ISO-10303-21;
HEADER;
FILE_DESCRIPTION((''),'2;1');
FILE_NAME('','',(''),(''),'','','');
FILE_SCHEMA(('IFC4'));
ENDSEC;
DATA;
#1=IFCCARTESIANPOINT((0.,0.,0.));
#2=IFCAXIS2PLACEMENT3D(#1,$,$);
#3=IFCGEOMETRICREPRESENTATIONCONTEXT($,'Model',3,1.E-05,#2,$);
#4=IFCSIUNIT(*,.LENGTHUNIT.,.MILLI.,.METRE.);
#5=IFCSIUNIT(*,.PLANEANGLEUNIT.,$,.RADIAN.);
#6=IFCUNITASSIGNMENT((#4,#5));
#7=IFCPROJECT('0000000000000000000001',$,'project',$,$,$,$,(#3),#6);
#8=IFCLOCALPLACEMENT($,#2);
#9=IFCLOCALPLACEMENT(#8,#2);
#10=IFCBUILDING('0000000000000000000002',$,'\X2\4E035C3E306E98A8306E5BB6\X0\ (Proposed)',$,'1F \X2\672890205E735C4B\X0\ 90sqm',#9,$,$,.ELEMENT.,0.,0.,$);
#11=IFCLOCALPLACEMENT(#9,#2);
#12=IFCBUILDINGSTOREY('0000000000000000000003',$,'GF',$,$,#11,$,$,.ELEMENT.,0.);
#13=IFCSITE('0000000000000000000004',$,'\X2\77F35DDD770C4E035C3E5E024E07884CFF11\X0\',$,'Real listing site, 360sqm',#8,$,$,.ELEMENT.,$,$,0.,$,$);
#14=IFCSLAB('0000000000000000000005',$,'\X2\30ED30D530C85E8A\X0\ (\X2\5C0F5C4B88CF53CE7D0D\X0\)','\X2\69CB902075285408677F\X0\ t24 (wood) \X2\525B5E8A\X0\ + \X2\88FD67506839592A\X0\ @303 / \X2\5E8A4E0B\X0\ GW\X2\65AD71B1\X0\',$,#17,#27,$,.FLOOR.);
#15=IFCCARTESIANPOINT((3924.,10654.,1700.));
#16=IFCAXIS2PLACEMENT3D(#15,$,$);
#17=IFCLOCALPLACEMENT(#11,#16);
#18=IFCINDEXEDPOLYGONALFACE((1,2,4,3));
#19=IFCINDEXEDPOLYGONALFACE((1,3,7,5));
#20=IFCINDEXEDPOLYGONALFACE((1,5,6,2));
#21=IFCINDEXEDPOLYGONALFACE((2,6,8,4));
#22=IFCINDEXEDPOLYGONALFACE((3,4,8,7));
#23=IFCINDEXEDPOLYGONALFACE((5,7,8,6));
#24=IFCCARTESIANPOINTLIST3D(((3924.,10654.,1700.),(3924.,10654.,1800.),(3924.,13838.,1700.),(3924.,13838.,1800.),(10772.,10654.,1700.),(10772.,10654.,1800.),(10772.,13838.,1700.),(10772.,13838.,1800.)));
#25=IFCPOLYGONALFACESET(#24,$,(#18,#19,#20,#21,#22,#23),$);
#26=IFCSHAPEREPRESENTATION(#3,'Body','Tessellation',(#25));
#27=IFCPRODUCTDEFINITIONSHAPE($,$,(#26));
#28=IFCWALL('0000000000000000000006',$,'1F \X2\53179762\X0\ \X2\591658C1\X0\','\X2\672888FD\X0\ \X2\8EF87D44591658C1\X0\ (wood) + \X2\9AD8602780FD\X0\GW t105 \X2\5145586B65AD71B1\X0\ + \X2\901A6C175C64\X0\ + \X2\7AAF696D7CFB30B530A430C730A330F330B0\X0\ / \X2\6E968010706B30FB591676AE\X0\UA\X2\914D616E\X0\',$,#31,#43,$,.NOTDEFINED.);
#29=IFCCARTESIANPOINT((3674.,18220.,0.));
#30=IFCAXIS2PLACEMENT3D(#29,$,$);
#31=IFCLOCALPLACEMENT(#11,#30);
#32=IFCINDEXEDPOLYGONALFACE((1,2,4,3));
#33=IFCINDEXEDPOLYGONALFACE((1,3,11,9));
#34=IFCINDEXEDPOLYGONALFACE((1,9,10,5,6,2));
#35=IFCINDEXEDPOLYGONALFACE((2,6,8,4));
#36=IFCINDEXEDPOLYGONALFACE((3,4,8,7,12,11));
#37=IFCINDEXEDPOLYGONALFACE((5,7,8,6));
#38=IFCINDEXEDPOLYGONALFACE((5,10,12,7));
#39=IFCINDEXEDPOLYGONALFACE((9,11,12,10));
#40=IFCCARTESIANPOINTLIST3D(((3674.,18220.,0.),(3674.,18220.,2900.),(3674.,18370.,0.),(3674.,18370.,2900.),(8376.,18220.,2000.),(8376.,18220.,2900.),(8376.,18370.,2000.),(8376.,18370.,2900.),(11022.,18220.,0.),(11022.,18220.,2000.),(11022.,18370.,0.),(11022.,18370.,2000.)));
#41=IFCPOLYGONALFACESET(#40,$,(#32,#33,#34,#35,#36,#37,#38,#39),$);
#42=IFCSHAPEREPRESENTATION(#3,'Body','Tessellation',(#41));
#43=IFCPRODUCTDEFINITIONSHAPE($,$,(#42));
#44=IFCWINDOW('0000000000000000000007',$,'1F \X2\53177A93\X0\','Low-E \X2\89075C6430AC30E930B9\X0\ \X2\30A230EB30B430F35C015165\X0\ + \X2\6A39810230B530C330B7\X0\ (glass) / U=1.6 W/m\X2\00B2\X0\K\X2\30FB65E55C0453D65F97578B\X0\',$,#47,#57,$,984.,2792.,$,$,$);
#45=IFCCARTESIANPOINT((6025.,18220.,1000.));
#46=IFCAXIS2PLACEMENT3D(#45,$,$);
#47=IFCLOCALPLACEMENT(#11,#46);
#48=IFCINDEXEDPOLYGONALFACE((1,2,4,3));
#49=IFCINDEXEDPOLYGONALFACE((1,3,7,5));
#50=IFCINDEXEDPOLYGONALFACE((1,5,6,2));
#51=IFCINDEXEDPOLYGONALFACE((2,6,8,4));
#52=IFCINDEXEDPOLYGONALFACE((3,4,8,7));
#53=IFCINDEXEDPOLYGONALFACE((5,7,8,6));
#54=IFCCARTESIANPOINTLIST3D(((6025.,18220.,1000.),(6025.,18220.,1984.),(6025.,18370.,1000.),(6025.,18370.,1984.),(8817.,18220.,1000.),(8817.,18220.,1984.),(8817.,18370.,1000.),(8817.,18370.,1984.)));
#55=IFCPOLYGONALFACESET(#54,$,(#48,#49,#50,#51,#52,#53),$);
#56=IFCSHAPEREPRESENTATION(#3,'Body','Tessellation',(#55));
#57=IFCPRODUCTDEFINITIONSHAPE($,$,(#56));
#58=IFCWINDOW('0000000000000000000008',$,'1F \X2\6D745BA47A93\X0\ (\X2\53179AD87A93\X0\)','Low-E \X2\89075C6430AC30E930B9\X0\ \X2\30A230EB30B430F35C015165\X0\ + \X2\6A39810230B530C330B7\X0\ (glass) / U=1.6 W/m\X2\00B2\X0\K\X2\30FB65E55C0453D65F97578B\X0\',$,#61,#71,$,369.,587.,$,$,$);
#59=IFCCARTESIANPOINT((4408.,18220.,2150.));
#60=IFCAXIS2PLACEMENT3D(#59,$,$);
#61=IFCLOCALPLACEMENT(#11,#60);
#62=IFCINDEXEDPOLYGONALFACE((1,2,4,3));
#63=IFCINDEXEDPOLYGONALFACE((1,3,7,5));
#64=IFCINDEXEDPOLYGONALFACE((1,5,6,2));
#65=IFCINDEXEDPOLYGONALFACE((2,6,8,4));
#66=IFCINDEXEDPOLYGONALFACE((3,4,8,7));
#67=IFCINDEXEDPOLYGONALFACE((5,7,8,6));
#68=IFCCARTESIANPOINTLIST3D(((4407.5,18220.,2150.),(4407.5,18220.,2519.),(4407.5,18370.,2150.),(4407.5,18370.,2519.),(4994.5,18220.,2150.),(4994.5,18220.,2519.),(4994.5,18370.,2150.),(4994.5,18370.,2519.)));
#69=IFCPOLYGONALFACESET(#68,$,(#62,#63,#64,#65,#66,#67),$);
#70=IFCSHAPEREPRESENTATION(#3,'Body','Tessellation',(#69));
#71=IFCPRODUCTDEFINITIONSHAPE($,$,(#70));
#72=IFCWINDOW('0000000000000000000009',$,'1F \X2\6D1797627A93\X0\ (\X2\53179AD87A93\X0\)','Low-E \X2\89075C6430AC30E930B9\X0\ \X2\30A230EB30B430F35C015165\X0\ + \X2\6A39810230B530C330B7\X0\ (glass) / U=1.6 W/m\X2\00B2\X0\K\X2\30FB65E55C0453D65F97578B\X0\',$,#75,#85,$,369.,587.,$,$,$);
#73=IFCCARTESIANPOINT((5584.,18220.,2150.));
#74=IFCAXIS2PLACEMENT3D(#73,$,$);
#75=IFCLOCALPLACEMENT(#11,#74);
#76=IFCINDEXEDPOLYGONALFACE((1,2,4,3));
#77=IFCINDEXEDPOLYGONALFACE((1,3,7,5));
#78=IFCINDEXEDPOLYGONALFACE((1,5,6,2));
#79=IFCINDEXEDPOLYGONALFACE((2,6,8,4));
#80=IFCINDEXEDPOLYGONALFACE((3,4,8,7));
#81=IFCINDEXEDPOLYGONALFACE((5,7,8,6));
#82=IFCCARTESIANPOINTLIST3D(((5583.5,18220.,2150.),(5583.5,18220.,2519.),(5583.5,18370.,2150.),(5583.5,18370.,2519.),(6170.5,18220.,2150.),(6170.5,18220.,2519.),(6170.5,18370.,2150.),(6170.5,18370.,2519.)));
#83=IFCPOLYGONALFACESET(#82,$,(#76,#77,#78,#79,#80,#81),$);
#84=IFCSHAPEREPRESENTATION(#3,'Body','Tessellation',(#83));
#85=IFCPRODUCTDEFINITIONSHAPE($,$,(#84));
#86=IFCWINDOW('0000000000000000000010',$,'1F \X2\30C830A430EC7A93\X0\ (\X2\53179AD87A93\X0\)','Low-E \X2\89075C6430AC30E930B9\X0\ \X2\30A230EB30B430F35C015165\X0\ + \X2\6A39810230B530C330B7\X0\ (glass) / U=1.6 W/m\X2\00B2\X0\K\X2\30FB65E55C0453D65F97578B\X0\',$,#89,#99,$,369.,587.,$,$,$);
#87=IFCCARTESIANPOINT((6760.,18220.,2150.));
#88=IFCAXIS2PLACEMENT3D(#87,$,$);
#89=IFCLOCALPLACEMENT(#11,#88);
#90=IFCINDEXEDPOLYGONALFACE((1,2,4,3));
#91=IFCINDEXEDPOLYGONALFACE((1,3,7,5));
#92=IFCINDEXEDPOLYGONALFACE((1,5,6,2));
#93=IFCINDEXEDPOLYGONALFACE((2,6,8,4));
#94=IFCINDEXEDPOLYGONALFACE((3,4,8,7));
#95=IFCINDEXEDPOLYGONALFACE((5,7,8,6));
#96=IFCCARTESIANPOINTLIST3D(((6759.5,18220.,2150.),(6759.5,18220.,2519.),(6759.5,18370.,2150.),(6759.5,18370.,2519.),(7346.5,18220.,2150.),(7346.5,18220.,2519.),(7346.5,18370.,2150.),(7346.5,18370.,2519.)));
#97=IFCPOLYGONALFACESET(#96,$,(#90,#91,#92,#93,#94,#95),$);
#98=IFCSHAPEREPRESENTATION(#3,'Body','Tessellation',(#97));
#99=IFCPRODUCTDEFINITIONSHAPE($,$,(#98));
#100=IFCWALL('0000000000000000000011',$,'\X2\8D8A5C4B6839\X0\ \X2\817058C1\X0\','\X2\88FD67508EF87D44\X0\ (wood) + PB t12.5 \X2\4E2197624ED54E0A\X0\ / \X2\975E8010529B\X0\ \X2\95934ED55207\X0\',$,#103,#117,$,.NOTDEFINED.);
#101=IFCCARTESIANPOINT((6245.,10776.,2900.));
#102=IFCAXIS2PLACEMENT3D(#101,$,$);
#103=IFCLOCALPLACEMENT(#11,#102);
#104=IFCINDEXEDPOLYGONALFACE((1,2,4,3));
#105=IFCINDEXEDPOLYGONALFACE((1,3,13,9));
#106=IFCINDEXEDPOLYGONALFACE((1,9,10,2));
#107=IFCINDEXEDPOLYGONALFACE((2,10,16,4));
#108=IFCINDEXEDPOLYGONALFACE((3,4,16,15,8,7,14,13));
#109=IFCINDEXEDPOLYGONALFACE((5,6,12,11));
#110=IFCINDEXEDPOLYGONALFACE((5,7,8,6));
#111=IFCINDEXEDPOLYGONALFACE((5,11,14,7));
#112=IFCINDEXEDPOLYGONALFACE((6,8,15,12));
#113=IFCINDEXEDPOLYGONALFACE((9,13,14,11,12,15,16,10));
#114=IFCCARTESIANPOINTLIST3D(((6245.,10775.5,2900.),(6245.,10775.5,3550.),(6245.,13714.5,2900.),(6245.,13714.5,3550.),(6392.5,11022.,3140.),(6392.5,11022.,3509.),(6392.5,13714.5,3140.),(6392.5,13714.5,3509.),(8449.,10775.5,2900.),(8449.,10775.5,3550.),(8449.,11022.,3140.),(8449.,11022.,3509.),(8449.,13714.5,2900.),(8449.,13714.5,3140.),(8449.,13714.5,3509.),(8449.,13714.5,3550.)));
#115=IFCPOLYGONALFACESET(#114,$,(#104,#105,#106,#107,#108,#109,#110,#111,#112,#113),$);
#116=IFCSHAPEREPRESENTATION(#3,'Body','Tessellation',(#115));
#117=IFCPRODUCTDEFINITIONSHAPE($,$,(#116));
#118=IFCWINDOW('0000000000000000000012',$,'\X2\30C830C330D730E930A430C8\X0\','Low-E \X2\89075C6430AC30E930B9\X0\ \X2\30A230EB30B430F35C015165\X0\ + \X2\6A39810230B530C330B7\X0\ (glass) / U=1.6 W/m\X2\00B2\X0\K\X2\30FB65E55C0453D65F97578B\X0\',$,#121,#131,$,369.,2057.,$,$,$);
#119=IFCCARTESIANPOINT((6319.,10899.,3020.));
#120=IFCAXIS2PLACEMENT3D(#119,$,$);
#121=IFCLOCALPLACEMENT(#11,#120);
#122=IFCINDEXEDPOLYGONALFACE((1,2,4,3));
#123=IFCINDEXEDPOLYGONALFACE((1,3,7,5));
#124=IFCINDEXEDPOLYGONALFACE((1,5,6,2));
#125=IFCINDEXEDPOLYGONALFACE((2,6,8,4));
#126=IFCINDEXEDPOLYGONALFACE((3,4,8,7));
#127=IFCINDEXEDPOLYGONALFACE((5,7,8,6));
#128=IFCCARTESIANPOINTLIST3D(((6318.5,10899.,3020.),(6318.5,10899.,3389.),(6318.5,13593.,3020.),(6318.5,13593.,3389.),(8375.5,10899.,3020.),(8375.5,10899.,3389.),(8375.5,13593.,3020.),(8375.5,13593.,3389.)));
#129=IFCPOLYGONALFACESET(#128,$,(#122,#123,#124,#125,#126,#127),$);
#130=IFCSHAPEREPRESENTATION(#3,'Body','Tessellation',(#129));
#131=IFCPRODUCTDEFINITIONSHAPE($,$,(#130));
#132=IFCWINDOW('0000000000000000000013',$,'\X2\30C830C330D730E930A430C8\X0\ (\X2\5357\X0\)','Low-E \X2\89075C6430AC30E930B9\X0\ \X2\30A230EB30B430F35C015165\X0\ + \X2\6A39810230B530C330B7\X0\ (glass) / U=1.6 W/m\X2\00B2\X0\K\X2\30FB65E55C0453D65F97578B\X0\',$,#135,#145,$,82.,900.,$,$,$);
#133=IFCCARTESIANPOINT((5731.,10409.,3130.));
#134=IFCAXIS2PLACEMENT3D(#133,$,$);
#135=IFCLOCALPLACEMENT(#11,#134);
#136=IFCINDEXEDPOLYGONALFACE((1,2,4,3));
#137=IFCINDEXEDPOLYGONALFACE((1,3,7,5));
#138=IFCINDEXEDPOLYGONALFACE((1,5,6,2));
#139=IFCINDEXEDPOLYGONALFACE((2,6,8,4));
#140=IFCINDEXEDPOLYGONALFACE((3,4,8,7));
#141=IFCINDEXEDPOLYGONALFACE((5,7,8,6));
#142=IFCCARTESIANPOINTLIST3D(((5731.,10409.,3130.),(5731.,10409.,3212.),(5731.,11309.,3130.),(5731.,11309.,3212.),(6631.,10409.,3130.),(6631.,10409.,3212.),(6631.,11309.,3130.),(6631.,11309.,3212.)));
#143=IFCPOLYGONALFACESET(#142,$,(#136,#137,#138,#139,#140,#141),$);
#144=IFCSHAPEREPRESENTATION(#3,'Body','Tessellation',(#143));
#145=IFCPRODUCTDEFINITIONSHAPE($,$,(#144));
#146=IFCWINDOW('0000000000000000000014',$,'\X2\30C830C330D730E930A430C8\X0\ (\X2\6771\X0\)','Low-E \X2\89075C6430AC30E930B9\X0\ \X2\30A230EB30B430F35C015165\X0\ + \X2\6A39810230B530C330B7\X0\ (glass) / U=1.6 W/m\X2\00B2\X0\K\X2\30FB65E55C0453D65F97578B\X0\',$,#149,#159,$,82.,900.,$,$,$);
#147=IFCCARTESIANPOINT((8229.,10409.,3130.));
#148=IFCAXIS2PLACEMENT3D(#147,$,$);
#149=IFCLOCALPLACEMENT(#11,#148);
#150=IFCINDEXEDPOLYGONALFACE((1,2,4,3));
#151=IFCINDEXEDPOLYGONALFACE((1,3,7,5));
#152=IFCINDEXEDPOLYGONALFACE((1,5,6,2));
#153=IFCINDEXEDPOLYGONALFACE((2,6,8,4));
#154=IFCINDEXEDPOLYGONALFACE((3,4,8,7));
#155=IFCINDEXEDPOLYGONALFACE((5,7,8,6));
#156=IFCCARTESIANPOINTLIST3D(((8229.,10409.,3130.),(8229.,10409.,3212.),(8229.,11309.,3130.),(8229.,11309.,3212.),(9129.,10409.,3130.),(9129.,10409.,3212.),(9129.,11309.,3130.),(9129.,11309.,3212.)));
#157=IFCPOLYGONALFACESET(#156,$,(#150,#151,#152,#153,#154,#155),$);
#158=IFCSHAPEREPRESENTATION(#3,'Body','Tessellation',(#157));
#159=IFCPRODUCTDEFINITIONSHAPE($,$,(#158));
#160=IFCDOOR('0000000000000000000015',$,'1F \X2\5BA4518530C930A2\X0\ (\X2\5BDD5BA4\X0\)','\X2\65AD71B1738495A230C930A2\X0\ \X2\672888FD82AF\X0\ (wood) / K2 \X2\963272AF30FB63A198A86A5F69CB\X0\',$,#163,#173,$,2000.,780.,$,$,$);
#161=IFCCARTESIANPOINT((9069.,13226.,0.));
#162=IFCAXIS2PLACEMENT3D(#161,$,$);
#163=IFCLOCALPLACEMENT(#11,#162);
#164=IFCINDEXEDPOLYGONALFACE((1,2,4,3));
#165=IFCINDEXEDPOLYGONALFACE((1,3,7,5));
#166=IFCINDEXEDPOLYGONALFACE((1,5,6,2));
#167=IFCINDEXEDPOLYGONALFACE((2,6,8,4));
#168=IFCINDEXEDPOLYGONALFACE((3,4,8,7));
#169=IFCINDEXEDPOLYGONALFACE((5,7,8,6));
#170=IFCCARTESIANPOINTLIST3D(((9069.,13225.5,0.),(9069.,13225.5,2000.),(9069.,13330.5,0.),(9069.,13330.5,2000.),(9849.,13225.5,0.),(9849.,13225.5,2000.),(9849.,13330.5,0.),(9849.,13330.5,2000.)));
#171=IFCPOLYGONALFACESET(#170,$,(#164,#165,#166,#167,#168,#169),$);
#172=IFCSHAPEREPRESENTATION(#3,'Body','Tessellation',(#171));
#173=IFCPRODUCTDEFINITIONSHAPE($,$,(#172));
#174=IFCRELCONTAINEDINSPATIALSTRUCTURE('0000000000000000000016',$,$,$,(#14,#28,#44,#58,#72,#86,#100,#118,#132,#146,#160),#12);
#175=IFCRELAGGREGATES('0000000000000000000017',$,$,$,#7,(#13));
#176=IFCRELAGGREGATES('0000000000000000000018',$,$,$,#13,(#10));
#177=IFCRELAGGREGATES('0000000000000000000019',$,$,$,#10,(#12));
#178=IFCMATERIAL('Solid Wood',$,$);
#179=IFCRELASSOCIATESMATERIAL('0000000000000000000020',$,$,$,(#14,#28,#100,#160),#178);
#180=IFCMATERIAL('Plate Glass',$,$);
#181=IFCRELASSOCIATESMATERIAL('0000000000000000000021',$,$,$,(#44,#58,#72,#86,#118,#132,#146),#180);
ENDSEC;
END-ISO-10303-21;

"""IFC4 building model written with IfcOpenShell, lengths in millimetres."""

from ifc_helpers import new_model, si_unit, frame, frame_2d, origin, place, context, project, spatial, rectangle, extrude, material, element, fill, save


model = new_model("IFC4")

# Units and contexts
model_context = context("Model", 3, precision=1e-05, world=origin())
ifc_project = project(units=[si_unit("LENGTHUNIT", "METRE", prefix="MILLI"), si_unit("PLANEANGLEUNIT", "RADIAN")], contexts=[model_context])

# Site, building, storey
site_placement = place(None, origin())
site = spatial("IfcSite", under=ifc_project, at=site_placement, Name="石川県七尾市万行１", ObjectType="Real listing site, 360sqm", CompositionType="ELEMENT", RefElevation=0.0)
building_placement = place(site_placement, origin())
building = spatial("IfcBuilding", under=site, at=building_placement, Name="七尾の風の家 (Proposed)", ObjectType="1F 木造平屋 90sqm", CompositionType="ELEMENT", ElevationOfRefHeight=0.0, ElevationOfTerrain=0.0)
storey_placement = place(building_placement, origin())
storey = spatial("IfcBuildingStorey", under=building, at=storey_placement, Name="GF", CompositionType="ELEMENT", Elevation=0.0)

# Slab
ifc_material_1 = material(Name="Solid Wood")
slab_placement = place(storey_placement, frame((3924.0, 10654.0, 1700.0)))
element("IfcSlab", 1, at=slab_placement, inside=storey, material=ifc_material_1, Name="ロフト床 (小屋裏収納)", Description="構造用合板 t24 (wood) 剛床 + 製材根太 @303 / 床下 GW断熱", PredefinedType="FLOOR", context=model_context, shape_type="SweptSolid", body=[
    extrude(rectangle(XDim=6848.0, YDim=3184.0, at=frame_2d((3424.0, 1592.0))), frame((3924.0, 10654.0, 1700.0)), (0.0, 0.0, 1.0), 100.0),
])

# Wall, openings, windows
wall_1_placement = place(storey_placement, frame((3674.0, 18220.0, 0.0)))
wall_1 = element("IfcWall", 2, at=wall_1_placement, inside=storey, material=ifc_material_1, Name="1F 北面 外壁", Description="木製 軸組外壁 (wood) + 高性能GW t105 充填断熱 + 通気層 + 窯業系サイディング / 準耐火・外皮UA配慮", PredefinedType="NOTDEFINED", context=model_context, shape_type="SweptSolid", body=[
    extrude(rectangle(XDim=7348.0, YDim=150.0, at=frame_2d((3674.0, 75.0))), frame((3674.0, 18220.0, 0.0)), (0.0, 0.0, 1.0), 2900.0),
])
opening_1_placement = place(storey_placement, frame((6025.0, 18220.0, 1000.0)))
opening_1 = element("IfcOpeningElement", 3, at=opening_1_placement, cuts=wall_1, PredefinedType="NOTDEFINED", context=model_context, shape_type="SweptSolid", body=[
    extrude(rectangle(XDim=2792.0, YDim=150.0, at=frame_2d((1396.0, 75.0))), frame((6025.0, 18220.0, 1000.0)), (0.0, 0.0, 1.0), 984.0),
])
opening_2_placement = place(storey_placement, frame((4408.0, 18220.0, 2150.0)))
opening_2 = element("IfcOpeningElement", 4, at=opening_2_placement, cuts=wall_1, PredefinedType="NOTDEFINED", context=model_context, shape_type="SweptSolid", body=[
    extrude(rectangle(XDim=587.0, YDim=150.0, at=frame_2d((293.0, 75.0))), frame((4408.0, 18220.0, 2150.0)), (0.0, 0.0, 1.0), 369.0),
])
opening_3_placement = place(storey_placement, frame((5584.0, 18220.0, 2150.0)))
opening_3 = element("IfcOpeningElement", 5, at=opening_3_placement, cuts=wall_1, PredefinedType="NOTDEFINED", context=model_context, shape_type="SweptSolid", body=[
    extrude(rectangle(XDim=587.0, YDim=150.0, at=frame_2d((293.0, 75.0))), frame((5584.0, 18220.0, 2150.0)), (0.0, 0.0, 1.0), 369.0),
])
opening_4_placement = place(storey_placement, frame((6760.0, 18220.0, 2150.0)))
opening_4 = element("IfcOpeningElement", 6, at=opening_4_placement, cuts=wall_1, PredefinedType="NOTDEFINED", context=model_context, shape_type="SweptSolid", body=[
    extrude(rectangle(XDim=587.0, YDim=150.0, at=frame_2d((293.0, 75.0))), frame((6760.0, 18220.0, 2150.0)), (0.0, 0.0, 1.0), 369.0),
])
ifc_material_2 = material(Name="Plate Glass")
window_1_placement = place(storey_placement, frame((6025.0, 18220.0, 1000.0)))
window_1 = element("IfcWindow", 7, at=window_1_placement, inside=storey, material=ifc_material_2, Name="1F 北窓", Description="Low-E 複層ガラス アルゴン封入 + 樹脂サッシ (glass) / U=1.6 W/m²K・日射取得型", OverallHeight=984.0, OverallWidth=2792.0, context=model_context, shape_type="SweptSolid", body=[
    extrude(rectangle(XDim=2792.0, YDim=150.0, at=frame_2d((1396.0, 75.0))), frame((6025.0, 18220.0, 1000.0)), (0.0, 0.0, 1.0), 984.0),
])
fill(opening_1, window_1)
window_2_placement = place(storey_placement, frame((4408.0, 18220.0, 2150.0)))
window_2 = element("IfcWindow", 8, at=window_2_placement, inside=storey, material=ifc_material_2, Name="1F 浴室窓 (北高窓)", Description="Low-E 複層ガラス アルゴン封入 + 樹脂サッシ (glass) / U=1.6 W/m²K・日射取得型", OverallHeight=369.0, OverallWidth=587.0, context=model_context, shape_type="SweptSolid", body=[
    extrude(rectangle(XDim=587.0, YDim=150.0, at=frame_2d((293.0, 75.0))), frame((4408.0, 18220.0, 2150.0)), (0.0, 0.0, 1.0), 369.0),
])
fill(opening_2, window_2)
window_3_placement = place(storey_placement, frame((5584.0, 18220.0, 2150.0)))
window_3 = element("IfcWindow", 9, at=window_3_placement, inside=storey, material=ifc_material_2, Name="1F 洗面窓 (北高窓)", Description="Low-E 複層ガラス アルゴン封入 + 樹脂サッシ (glass) / U=1.6 W/m²K・日射取得型", OverallHeight=369.0, OverallWidth=587.0, context=model_context, shape_type="SweptSolid", body=[
    extrude(rectangle(XDim=587.0, YDim=150.0, at=frame_2d((293.0, 75.0))), frame((5584.0, 18220.0, 2150.0)), (0.0, 0.0, 1.0), 369.0),
])
fill(opening_3, window_3)
window_4_placement = place(storey_placement, frame((6760.0, 18220.0, 2150.0)))
window_4 = element("IfcWindow", 10, at=window_4_placement, inside=storey, material=ifc_material_2, Name="1F トイレ窓 (北高窓)", Description="Low-E 複層ガラス アルゴン封入 + 樹脂サッシ (glass) / U=1.6 W/m²K・日射取得型", OverallHeight=369.0, OverallWidth=587.0, context=model_context, shape_type="SweptSolid", body=[
    extrude(rectangle(XDim=587.0, YDim=150.0, at=frame_2d((293.0, 75.0))), frame((6760.0, 18220.0, 2150.0)), (0.0, 0.0, 1.0), 369.0),
])
fill(opening_4, window_4)

# Wall, openings, windows
wall_2_placement = place(storey_placement, frame((6245.0, 10776.0, 2900.0)))
wall_2 = element("IfcWall", 11, at=wall_2_placement, inside=storey, material=ifc_material_1, Name="越屋根 腰壁", Description="製材軸組 (wood) + PB t12.5 両面仕上 / 非耐力 間仕切", PredefinedType="NOTDEFINED", context=model_context, shape_type="SweptSolid", body=[
    extrude(rectangle(XDim=2204.0, YDim=2939.0, at=frame_2d((1102.0, 1469.0))), frame((6245.0, 10776.0, 2900.0)), (0.0, 0.0, 1.0), 650.0),
])
opening_5_placement = place(storey_placement, frame((6319.0, 10899.0, 3020.0)))
opening_5 = element("IfcOpeningElement", 12, at=opening_5_placement, cuts=wall_2, PredefinedType="NOTDEFINED", context=model_context, shape_type="SweptSolid", body=[
    extrude(rectangle(XDim=2057.0, YDim=2694.0, at=frame_2d((1028.0, 1347.0))), frame((6319.0, 10899.0, 3020.0)), (0.0, 0.0, 1.0), 369.0),
])
opening_6_placement = place(storey_placement, frame((5731.0, 10409.0, 3130.0)))
opening_6 = element("IfcOpeningElement", 13, at=opening_6_placement, cuts=wall_2, PredefinedType="NOTDEFINED", context=model_context, shape_type="SweptSolid", body=[
    extrude(rectangle(XDim=900.0, YDim=900.0, at=frame_2d((450.0, 450.0))), frame((5731.0, 10409.0, 3130.0)), (0.0, 0.0, 1.0), 82.0),
])
opening_7_placement = place(storey_placement, frame((8229.0, 10409.0, 3130.0)))
opening_7 = element("IfcOpeningElement", 14, at=opening_7_placement, cuts=wall_2, PredefinedType="NOTDEFINED", context=model_context, shape_type="SweptSolid", body=[
    extrude(rectangle(XDim=900.0, YDim=900.0, at=frame_2d((450.0, 450.0))), frame((8229.0, 10409.0, 3130.0)), (0.0, 0.0, 1.0), 82.0),
])
window_5_placement = place(storey_placement, frame((6319.0, 10899.0, 3020.0)))
window_5 = element("IfcWindow", 15, at=window_5_placement, inside=storey, material=ifc_material_2, Name="トップライト", Description="Low-E 複層ガラス アルゴン封入 + 樹脂サッシ (glass) / U=1.6 W/m²K・日射取得型", OverallHeight=369.0, OverallWidth=2057.0, context=model_context, shape_type="SweptSolid", body=[
    extrude(rectangle(XDim=2057.0, YDim=2694.0, at=frame_2d((1028.0, 1347.0))), frame((6319.0, 10899.0, 3020.0)), (0.0, 0.0, 1.0), 369.0),
])
fill(opening_5, window_5)
window_6_placement = place(storey_placement, frame((5731.0, 10409.0, 3130.0)))
window_6 = element("IfcWindow", 16, at=window_6_placement, inside=storey, material=ifc_material_2, Name="トップライト (南)", Description="Low-E 複層ガラス アルゴン封入 + 樹脂サッシ (glass) / U=1.6 W/m²K・日射取得型", OverallHeight=82.0, OverallWidth=900.0, context=model_context, shape_type="SweptSolid", body=[
    extrude(rectangle(XDim=900.0, YDim=900.0, at=frame_2d((450.0, 450.0))), frame((5731.0, 10409.0, 3130.0)), (0.0, 0.0, 1.0), 82.0),
])
fill(opening_6, window_6)
window_7_placement = place(storey_placement, frame((8229.0, 10409.0, 3130.0)))
window_7 = element("IfcWindow", 17, at=window_7_placement, inside=storey, material=ifc_material_2, Name="トップライト (東)", Description="Low-E 複層ガラス アルゴン封入 + 樹脂サッシ (glass) / U=1.6 W/m²K・日射取得型", OverallHeight=82.0, OverallWidth=900.0, context=model_context, shape_type="SweptSolid", body=[
    extrude(rectangle(XDim=900.0, YDim=900.0, at=frame_2d((450.0, 450.0))), frame((8229.0, 10409.0, 3130.0)), (0.0, 0.0, 1.0), 82.0),
])
fill(opening_7, window_7)

# Door
door_1_placement = place(storey_placement, frame((9069.0, 13226.0, 0.0)))
element("IfcDoor", 18, at=door_1_placement, inside=storey, material=ifc_material_1, Name="1F 室内ドア (寝室)", Description="断熱玄関ドア 木製芯 (wood) / K2 防犯・採風機構", OverallHeight=2000.0, OverallWidth=780.0, context=model_context, shape_type="SweptSolid", body=[
    extrude(rectangle(XDim=780.0, YDim=105.0, at=frame_2d((390.0, 52.0))), frame((9069.0, 13226.0, 0.0)), (0.0, 0.0, 1.0), 2000.0),
])

save(model, "model.ifc")
